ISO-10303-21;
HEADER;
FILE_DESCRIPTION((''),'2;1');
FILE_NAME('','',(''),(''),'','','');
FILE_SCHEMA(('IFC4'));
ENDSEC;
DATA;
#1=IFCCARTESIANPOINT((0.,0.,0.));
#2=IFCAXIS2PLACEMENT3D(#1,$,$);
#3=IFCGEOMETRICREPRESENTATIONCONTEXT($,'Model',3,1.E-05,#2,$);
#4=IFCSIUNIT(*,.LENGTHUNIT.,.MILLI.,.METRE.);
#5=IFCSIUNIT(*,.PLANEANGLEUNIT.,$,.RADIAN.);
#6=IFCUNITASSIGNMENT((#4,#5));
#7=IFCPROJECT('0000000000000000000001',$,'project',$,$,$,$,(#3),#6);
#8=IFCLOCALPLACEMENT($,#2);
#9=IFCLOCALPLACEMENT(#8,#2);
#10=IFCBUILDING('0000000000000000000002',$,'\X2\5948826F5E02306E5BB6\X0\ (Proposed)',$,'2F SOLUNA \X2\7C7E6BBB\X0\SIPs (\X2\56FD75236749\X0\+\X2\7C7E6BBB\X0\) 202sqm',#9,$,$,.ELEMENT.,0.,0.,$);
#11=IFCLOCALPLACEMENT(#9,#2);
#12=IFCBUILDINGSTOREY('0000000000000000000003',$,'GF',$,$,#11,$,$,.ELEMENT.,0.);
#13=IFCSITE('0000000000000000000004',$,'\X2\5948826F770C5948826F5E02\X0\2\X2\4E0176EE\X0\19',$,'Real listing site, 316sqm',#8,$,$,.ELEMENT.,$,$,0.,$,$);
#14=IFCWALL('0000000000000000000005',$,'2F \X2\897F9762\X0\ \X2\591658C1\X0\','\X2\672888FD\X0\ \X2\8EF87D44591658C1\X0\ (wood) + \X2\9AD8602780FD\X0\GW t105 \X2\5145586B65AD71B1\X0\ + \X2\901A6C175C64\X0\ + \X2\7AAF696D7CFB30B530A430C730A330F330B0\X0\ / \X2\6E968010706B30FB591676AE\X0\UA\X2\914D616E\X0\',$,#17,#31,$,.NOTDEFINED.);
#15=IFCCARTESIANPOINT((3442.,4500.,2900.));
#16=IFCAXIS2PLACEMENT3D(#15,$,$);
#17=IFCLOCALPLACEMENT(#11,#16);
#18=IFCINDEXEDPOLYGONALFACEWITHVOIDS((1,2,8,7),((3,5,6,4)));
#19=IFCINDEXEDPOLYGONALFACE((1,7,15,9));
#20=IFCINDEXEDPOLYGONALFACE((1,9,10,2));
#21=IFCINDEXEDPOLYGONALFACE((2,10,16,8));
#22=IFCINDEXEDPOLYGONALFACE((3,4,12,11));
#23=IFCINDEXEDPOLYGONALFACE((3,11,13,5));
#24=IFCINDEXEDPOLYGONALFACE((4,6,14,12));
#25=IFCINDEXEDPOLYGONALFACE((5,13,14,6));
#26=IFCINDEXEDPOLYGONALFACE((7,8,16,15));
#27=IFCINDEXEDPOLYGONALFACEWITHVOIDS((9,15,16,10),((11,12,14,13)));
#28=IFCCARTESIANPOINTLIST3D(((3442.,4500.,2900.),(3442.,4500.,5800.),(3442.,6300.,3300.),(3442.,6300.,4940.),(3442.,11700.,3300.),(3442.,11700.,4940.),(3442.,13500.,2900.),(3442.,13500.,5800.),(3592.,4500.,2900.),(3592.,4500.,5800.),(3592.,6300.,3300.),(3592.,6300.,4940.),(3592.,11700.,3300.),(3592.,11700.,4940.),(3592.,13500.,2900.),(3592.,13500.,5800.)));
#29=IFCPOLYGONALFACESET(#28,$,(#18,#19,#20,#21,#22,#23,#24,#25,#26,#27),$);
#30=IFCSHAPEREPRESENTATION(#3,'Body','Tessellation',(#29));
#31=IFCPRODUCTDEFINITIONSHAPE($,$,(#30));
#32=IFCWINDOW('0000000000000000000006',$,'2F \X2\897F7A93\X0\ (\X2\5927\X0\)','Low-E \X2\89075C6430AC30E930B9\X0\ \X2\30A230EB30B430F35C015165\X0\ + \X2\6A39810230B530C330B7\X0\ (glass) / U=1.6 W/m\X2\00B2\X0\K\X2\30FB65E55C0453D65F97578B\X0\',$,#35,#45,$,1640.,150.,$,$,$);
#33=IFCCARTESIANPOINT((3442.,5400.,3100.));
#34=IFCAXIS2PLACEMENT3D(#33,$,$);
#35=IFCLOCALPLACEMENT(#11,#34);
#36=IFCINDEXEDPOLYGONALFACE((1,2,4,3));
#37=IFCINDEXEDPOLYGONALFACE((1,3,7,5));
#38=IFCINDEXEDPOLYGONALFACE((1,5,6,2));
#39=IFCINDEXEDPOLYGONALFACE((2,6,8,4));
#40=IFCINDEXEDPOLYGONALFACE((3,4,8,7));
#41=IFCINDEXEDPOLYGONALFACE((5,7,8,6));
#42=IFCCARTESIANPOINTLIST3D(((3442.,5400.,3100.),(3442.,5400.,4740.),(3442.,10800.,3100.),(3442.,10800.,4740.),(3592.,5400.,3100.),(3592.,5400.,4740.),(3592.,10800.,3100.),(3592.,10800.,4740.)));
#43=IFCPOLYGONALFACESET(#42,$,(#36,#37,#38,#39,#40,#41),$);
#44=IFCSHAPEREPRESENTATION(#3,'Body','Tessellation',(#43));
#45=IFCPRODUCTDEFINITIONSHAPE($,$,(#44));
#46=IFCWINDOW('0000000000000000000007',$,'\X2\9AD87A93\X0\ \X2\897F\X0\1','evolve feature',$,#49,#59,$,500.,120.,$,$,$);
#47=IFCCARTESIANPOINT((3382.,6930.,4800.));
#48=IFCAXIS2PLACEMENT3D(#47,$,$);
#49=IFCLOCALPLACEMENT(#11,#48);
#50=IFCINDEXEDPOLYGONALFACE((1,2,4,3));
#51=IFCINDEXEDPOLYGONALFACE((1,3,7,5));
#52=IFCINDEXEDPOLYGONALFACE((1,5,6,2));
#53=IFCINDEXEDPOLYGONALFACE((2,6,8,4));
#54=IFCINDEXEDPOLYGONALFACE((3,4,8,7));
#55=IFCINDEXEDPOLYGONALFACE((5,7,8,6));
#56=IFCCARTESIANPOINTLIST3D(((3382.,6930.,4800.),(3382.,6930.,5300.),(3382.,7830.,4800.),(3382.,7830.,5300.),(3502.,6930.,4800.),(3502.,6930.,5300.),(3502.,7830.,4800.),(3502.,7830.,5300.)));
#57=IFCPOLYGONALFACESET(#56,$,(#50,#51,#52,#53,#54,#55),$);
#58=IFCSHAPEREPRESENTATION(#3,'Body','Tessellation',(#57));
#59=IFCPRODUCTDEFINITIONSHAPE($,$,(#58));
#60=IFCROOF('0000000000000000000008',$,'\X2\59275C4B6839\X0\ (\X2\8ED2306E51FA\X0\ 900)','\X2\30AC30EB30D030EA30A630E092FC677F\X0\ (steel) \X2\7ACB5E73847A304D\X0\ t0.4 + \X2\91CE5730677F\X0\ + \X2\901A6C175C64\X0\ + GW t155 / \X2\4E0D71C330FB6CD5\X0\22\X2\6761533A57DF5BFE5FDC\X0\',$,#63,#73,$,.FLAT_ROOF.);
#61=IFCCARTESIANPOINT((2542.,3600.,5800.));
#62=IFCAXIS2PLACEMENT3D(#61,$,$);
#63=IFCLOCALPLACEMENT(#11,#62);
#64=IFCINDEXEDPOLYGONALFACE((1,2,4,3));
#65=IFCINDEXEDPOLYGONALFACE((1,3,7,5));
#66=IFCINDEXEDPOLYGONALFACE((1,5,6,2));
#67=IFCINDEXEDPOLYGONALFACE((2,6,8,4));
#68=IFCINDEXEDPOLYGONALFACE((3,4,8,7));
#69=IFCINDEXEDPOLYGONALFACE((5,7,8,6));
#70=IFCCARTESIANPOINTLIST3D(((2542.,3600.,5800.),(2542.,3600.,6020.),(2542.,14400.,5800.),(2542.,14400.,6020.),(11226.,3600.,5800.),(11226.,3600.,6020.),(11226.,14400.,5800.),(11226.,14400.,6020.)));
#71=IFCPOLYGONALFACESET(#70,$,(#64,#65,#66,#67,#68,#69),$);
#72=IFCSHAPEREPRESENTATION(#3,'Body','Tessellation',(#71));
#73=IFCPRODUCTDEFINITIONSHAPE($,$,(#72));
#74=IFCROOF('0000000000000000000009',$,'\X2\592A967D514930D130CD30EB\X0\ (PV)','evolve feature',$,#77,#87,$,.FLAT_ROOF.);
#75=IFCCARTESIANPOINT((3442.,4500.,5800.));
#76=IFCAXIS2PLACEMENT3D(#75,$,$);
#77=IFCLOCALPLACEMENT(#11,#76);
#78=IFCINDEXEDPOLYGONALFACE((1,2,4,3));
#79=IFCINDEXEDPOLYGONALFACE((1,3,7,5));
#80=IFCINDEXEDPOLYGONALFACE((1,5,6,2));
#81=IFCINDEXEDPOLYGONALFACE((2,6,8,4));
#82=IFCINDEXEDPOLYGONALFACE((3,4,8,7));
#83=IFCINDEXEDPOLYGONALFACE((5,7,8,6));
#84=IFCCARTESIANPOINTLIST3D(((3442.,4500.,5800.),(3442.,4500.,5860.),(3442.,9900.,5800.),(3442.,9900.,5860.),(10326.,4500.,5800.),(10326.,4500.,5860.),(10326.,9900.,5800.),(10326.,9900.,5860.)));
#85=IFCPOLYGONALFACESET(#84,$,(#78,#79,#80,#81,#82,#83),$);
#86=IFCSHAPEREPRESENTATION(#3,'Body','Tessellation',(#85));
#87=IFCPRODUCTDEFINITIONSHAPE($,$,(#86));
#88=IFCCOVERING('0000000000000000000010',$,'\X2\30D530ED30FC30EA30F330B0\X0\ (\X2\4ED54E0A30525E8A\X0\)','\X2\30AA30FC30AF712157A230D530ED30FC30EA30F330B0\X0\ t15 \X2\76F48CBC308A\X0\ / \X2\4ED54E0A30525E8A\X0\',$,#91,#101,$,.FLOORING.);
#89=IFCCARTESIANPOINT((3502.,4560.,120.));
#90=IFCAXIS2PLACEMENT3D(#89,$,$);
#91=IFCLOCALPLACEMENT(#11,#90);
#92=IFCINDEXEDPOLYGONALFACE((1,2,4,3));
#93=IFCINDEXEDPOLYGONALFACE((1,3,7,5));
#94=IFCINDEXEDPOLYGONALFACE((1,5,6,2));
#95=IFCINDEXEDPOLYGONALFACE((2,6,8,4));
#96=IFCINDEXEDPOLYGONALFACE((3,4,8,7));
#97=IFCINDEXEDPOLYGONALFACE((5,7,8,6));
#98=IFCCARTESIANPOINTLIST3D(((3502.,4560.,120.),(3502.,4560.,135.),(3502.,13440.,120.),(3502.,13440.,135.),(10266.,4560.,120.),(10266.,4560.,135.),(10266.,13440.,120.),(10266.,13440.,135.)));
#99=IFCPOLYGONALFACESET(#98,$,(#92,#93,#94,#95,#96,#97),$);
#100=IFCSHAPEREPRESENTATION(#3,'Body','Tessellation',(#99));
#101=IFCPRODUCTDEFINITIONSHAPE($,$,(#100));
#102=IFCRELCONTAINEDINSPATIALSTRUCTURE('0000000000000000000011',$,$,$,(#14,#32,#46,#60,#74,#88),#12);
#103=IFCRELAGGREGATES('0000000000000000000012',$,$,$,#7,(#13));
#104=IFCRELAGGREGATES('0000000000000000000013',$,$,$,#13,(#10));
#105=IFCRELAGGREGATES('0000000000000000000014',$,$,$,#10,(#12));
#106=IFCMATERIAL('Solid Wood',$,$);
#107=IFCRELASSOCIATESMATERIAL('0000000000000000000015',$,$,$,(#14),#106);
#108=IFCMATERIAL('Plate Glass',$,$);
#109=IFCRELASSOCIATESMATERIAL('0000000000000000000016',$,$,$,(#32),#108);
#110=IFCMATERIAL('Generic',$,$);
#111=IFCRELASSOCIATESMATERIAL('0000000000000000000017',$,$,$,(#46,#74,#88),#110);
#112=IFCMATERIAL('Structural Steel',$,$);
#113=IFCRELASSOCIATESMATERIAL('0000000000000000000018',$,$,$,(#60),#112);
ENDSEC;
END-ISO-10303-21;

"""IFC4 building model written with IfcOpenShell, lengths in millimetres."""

from ifc_helpers import new_model, si_unit, frame, frame_2d, origin, place, context, project, spatial, rectangle, extrude, material, element, fill, save


model = new_model("IFC4")

# Units and contexts
model_context = context("Model", 3, precision=1e-05, world=origin())
ifc_project = project(units=[si_unit("LENGTHUNIT", "METRE", prefix="MILLI"), si_unit("PLANEANGLEUNIT", "RADIAN")], contexts=[model_context])

# Site, building, storey
site_placement = place(None, origin())
site = spatial("IfcSite", under=ifc_project, at=site_placement, Name="奈良県奈良市2丁目19", ObjectType="Real listing site, 316sqm", CompositionType="ELEMENT", RefElevation=0.0)
building_placement = place(site_placement, origin())
building = spatial("IfcBuilding", under=site, at=building_placement, Name="奈良市の家 (Proposed)", ObjectType="2F SOLUNA 籾殻SIPs (国産杉+籾殻) 202sqm", CompositionType="ELEMENT", ElevationOfRefHeight=0.0, ElevationOfTerrain=0.0)
storey_placement = place(building_placement, origin())
storey = spatial("IfcBuildingStorey", under=building, at=storey_placement, Name="GF", CompositionType="ELEMENT", Elevation=0.0)

# Shared definitions
ifc_material_1 = material(Name="Solid Wood")

# Shared definitions
ifc_material_2 = material(Name="Plate Glass")
ifc_material_3 = material(Name="Generic")

# Wall, openings, windows
wall_1_placement = place(storey_placement, frame((3442.0, 4500.0, 2900.0)))
wall_1 = element("IfcWall", 1, at=wall_1_placement, inside=storey, material=ifc_material_1, Name="2F 西面 外壁", Description="木製 軸組外壁 (wood) + 高性能GW t105 充填断熱 + 通気層 + 窯業系サイディング / 準耐火・外皮UA配慮", PredefinedType="NOTDEFINED", context=model_context, shape_type="SweptSolid", body=[
    extrude(rectangle(XDim=150.0, YDim=9000.0, at=frame_2d((75.0, 4500.0))), frame((3442.0, 4500.0, 2900.0)), (0.0, 0.0, 1.0), 2900.0),
])
opening_1_placement = place(storey_placement, frame((3442.0, 5400.0, 3100.0)))
opening_1 = element("IfcOpeningElement", 2, at=opening_1_placement, cuts=wall_1, PredefinedType="NOTDEFINED", context=model_context, shape_type="SweptSolid", body=[
    extrude(rectangle(XDim=150.0, YDim=5400.0, at=frame_2d((75.0, 2700.0))), frame((3442.0, 5400.0, 3100.0)), (0.0, 0.0, 1.0), 1640.0),
])
opening_2_placement = place(storey_placement, frame((3382.0, 6930.0, 4800.0)))
opening_2 = element("IfcOpeningElement", 3, at=opening_2_placement, cuts=wall_1, PredefinedType="NOTDEFINED", context=model_context, shape_type="SweptSolid", body=[
    extrude(rectangle(XDim=120.0, YDim=900.0, at=frame_2d((60.0, 450.0))), frame((3382.0, 6930.0, 4800.0)), (0.0, 0.0, 1.0), 500.0),
])
window_1_placement = place(storey_placement, frame((3442.0, 5400.0, 3100.0)))
window_1 = element("IfcWindow", 4, at=window_1_placement, inside=storey, material=ifc_material_2, Name="2F 西窓 (大)", Description="Low-E 複層ガラス アルゴン封入 + 樹脂サッシ (glass) / U=1.6 W/m²K・日射取得型", OverallHeight=1640.0, OverallWidth=150.0, context=model_context, shape_type="SweptSolid", body=[
    extrude(rectangle(XDim=150.0, YDim=5400.0, at=frame_2d((75.0, 2700.0))), frame((3442.0, 5400.0, 3100.0)), (0.0, 0.0, 1.0), 1640.0),
])
fill(opening_1, window_1)
window_2_placement = place(storey_placement, frame((3382.0, 6930.0, 4800.0)))
window_2 = element("IfcWindow", 5, at=window_2_placement, inside=storey, material=ifc_material_3, Name="高窓 西1", Description="evolve feature", OverallHeight=500.0, OverallWidth=120.0, context=model_context, shape_type="SweptSolid", body=[
    extrude(rectangle(XDim=120.0, YDim=900.0, at=frame_2d((60.0, 450.0))), frame((3382.0, 6930.0, 4800.0)), (0.0, 0.0, 1.0), 500.0),
])
fill(opening_2, window_2)

# Roofs
ifc_material_4 = material(Name="Structural Steel")
roof_1_placement = place(storey_placement, frame((2542.0, 3600.0, 5800.0)))
element("IfcRoof", 6, at=roof_1_placement, inside=storey, material=ifc_material_4, Name="大屋根 (軒の出 900)", Description="ガルバリウム鋼板 (steel) 立平葺き t0.4 + 野地板 + 通気層 + GW t155 / 不燃・法22条区域対応", PredefinedType="FLAT_ROOF", context=model_context, shape_type="SweptSolid", body=[
    extrude(rectangle(XDim=8684.0, YDim=10800.0, at=frame_2d((4342.0, 5400.0))), frame((2542.0, 3600.0, 5800.0)), (0.0, 0.0, 1.0), 220.0),
])
roof_2_placement = place(storey_placement, frame((3442.0, 4500.0, 5800.0)))
element("IfcRoof", 7, at=roof_2_placement, inside=storey, material=ifc_material_3, Name="太陽光パネル (PV)", Description="evolve feature", PredefinedType="FLAT_ROOF", context=model_context, shape_type="SweptSolid", body=[
    extrude(rectangle(XDim=6884.0, YDim=5400.0, at=frame_2d((3442.0, 2700.0))), frame((3442.0, 4500.0, 5800.0)), (0.0, 0.0, 1.0), 60.0),
])

# Covering
covering_placement = place(storey_placement, frame((3502.0, 4560.0, 120.0)))
element("IfcCovering", 8, at=covering_placement, inside=storey, material=ifc_material_3, Name="フローリング (仕上げ床)", Description="オーク無垢フローリング t15 直貼り / 仕上げ床", PredefinedType="FLOORING", context=model_context, shape_type="SweptSolid", body=[
    extrude(rectangle(XDim=6764.0, YDim=8880.0, at=frame_2d((3382.0, 4440.0))), frame((3502.0, 4560.0, 120.0)), (0.0, 0.0, 1.0), 15.0),
])

save(model, "model.ifc")
